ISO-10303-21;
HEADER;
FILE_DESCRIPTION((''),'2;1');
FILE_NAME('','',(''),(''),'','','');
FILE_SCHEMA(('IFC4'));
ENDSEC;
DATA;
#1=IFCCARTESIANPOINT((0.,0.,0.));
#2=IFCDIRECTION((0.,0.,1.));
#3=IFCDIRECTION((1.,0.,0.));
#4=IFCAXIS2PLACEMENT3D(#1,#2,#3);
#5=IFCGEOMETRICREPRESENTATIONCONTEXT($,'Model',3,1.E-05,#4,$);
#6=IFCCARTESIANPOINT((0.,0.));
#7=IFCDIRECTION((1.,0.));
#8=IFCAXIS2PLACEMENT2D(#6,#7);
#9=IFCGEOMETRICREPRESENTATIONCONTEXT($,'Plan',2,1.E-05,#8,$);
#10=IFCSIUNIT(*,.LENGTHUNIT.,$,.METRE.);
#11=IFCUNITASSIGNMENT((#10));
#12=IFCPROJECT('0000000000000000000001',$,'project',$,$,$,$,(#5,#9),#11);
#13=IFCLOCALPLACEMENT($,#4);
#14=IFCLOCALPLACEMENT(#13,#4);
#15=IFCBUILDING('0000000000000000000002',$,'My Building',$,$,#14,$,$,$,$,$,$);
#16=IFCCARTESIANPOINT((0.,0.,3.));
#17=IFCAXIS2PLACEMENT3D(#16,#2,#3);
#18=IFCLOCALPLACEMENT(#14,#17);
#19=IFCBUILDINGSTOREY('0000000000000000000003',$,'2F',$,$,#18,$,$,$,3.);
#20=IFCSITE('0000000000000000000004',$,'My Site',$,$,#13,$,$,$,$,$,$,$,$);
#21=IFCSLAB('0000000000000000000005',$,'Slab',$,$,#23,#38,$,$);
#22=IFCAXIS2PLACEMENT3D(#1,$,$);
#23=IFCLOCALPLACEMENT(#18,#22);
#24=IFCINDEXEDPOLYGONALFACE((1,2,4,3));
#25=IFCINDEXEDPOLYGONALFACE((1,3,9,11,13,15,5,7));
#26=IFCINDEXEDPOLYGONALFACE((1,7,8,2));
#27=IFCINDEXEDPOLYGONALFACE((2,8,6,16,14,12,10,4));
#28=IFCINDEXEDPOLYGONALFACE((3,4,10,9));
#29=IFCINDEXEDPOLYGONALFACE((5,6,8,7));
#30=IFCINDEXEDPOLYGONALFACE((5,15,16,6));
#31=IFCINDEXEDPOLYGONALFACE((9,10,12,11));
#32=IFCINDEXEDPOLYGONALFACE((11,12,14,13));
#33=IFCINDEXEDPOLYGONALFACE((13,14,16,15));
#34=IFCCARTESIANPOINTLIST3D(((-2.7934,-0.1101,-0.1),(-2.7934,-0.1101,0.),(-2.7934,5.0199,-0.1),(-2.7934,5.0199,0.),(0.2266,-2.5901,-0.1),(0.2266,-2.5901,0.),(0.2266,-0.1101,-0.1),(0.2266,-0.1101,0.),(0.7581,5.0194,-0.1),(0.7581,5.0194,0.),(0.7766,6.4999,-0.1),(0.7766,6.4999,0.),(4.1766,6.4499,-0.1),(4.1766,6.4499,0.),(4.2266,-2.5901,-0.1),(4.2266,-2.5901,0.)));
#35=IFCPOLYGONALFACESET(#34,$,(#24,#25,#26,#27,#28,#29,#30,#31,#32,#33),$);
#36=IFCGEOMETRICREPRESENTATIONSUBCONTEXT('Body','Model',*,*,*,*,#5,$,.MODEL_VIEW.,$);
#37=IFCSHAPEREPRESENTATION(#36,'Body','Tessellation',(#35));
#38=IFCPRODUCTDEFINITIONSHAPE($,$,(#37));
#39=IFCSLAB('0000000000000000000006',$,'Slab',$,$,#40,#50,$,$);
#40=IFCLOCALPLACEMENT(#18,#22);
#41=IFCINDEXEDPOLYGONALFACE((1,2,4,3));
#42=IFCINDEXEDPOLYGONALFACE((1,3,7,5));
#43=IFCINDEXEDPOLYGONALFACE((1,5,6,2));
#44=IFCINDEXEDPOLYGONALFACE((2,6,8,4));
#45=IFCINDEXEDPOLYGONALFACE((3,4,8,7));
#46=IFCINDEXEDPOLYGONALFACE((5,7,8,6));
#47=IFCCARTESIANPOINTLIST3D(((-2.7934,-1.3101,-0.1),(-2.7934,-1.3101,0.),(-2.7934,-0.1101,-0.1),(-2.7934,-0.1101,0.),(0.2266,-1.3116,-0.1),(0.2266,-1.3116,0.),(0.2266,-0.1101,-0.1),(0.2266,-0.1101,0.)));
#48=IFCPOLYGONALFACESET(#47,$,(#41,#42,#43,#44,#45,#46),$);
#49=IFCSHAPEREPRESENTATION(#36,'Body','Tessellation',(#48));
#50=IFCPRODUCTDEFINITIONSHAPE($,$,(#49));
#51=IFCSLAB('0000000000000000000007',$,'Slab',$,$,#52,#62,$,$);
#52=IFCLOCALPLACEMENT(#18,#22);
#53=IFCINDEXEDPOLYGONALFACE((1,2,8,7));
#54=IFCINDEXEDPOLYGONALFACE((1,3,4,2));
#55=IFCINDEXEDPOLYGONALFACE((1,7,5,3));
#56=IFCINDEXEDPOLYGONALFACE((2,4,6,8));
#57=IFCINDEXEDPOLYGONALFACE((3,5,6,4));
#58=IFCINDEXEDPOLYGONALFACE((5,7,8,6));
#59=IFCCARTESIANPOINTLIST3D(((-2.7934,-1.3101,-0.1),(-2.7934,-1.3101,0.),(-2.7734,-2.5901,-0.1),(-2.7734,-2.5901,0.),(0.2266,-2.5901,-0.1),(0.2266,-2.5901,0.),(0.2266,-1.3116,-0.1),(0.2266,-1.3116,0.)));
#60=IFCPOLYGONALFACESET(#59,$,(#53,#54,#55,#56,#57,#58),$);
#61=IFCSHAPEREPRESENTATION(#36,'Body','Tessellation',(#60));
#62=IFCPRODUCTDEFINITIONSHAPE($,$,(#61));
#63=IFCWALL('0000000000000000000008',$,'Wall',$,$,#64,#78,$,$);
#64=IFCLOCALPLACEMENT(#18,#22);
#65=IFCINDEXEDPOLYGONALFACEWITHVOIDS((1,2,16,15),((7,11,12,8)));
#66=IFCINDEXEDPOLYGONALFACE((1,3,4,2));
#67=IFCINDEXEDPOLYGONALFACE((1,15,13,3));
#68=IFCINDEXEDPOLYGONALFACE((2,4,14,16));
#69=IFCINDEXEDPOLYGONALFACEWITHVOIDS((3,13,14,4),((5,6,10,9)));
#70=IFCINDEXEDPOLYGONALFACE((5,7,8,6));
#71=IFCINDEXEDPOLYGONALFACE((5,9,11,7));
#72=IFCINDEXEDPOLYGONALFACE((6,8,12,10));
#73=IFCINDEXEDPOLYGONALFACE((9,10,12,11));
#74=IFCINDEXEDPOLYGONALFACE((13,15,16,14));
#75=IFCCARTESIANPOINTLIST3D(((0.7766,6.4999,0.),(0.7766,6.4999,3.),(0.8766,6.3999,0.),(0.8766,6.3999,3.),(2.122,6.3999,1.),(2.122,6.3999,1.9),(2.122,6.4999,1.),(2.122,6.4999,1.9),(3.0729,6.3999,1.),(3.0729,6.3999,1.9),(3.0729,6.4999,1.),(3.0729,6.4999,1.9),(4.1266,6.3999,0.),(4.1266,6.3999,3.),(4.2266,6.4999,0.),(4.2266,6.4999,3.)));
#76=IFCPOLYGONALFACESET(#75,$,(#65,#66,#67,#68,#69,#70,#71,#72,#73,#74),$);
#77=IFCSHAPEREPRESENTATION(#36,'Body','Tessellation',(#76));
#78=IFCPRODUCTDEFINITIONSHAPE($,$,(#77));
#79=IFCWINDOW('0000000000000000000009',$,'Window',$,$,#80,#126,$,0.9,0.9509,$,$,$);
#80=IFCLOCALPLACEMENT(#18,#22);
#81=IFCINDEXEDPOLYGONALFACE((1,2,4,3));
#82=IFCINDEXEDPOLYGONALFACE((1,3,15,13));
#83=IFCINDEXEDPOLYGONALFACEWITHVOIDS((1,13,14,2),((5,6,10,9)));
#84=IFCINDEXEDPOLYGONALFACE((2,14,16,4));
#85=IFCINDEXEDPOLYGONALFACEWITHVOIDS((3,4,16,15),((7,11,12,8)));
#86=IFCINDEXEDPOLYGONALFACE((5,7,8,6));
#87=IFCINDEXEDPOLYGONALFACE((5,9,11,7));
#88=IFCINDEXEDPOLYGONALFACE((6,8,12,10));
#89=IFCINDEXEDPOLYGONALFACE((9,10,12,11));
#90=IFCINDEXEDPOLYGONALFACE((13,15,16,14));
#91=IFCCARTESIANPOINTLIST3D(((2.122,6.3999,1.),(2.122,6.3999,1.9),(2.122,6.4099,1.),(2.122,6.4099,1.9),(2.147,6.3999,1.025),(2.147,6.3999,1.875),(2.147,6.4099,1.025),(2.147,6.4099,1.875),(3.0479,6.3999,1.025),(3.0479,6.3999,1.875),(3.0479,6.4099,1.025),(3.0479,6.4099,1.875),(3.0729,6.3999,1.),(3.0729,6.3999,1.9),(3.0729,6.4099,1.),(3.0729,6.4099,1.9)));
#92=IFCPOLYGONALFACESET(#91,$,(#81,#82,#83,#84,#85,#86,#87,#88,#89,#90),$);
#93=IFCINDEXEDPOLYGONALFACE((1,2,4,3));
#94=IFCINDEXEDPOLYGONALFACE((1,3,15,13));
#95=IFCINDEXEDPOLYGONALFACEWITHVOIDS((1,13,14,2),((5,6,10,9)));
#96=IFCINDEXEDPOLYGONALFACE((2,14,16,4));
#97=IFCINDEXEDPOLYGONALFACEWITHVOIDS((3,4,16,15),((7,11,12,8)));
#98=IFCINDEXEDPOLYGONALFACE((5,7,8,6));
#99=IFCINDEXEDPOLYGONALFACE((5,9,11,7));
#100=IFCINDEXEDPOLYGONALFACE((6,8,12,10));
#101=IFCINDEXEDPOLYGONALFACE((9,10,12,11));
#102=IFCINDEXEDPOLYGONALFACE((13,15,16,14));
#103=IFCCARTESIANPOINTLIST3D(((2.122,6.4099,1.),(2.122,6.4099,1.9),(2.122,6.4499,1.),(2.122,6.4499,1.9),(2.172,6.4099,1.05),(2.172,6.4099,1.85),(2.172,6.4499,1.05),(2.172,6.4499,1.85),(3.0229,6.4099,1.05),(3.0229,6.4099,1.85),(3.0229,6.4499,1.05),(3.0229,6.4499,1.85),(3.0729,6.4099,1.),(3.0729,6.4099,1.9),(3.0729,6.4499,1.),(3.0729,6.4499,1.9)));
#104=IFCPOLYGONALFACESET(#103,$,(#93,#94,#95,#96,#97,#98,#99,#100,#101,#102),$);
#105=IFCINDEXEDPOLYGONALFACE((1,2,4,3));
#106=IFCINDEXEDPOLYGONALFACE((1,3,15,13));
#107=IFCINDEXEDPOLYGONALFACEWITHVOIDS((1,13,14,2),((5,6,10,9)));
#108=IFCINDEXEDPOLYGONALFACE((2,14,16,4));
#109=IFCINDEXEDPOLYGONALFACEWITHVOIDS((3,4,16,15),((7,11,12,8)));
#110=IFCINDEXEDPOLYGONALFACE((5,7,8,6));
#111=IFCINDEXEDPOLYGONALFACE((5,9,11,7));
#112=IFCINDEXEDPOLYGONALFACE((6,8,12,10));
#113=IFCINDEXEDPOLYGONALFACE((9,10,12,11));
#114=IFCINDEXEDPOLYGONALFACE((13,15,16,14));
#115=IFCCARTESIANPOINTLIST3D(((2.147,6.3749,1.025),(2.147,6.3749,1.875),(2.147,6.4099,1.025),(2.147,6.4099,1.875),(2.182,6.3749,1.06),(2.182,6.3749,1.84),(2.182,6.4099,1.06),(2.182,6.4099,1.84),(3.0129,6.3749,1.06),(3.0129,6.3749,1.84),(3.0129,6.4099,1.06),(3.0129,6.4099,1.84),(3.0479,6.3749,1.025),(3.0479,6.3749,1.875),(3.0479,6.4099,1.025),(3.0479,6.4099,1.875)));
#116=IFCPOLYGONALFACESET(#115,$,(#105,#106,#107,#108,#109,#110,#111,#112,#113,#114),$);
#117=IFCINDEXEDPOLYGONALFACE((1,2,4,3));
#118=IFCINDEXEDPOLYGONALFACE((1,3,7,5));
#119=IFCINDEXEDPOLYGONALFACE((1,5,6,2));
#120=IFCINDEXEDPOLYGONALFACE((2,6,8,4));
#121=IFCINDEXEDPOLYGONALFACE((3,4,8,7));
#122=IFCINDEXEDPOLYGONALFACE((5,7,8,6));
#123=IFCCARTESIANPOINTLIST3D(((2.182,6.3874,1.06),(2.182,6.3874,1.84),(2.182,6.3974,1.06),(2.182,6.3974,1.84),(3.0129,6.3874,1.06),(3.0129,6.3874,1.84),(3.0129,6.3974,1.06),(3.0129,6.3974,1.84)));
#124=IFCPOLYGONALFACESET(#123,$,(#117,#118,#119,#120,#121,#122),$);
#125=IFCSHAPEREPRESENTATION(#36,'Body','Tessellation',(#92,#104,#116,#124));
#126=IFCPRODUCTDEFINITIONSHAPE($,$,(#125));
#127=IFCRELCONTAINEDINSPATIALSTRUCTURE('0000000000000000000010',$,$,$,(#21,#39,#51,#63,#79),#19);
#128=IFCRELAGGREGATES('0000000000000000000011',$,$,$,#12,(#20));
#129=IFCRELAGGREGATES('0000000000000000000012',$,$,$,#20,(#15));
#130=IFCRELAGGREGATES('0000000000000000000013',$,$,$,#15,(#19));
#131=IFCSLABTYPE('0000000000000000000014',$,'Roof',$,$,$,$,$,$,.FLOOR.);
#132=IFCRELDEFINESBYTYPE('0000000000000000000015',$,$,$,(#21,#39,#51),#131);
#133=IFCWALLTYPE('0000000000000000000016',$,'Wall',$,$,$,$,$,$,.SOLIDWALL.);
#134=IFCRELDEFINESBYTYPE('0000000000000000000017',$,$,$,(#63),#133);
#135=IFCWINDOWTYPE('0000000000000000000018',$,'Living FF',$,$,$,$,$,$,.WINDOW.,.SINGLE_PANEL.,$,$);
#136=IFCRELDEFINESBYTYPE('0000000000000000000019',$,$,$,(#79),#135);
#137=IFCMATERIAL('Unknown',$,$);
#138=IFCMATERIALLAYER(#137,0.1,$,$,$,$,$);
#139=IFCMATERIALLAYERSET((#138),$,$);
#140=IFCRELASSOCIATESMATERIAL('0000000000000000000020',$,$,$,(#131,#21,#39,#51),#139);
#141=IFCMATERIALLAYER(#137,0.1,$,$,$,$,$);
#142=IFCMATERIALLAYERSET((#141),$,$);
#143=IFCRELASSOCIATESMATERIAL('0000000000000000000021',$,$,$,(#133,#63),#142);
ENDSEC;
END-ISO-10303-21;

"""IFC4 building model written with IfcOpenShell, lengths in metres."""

from ifc_helpers import new_model, entity, si_unit, frame, origin_with_axes, origin_2d_with_axis, place, context, subcontext, project, spatial, line, indexed_curve, outline, extrude, shape, source, transform, mapped, material, layer, layer_set, layer_usage, type_object, type_shapes, element, fill, save


model = new_model("IFC4")

# Units and contexts
model_context = context("Model", 3, precision=1e-05, world=origin_with_axes())
plan_context = context("Plan", 2, precision=1e-05, world=origin_2d_with_axis())
body_context_1 = subcontext(model_context, "Body", "Model", "MODEL_VIEW")
body_context_2 = subcontext(plan_context, "Body", "Plan", "PLAN_VIEW")
ifc_project = project(units=[si_unit("LENGTHUNIT", "METRE")], contexts=[model_context, plan_context])

# Site, building, storey
site_placement = place(None, origin_with_axes())
site = spatial("IfcSite", under=ifc_project, at=site_placement, Name="My Site")
building_placement = place(site_placement, origin_with_axes())
building = spatial("IfcBuilding", under=site, at=building_placement, Name="My Building")
storey_placement = place(building_placement, frame((0.0, 0.0, 3.0), z_axis=(0.0, 0.0, 1.0), x_axis=(1.0, 0.0, 0.0)))
storey = spatial("IfcBuildingStorey", under=building, at=storey_placement, Name="2F", Elevation=3.0)

# Slabs
ifc_material = material(Name="Unknown")
ifc_layer_1 = layer(ifc_material, 0.1)
ifc_layer_set_1 = layer_set([ifc_layer_1])
ifc_layer_usage_1 = layer_usage(ifc_layer_set_1, "AXIS3", "POSITIVE", -0.1)
slab_type = type_object("IfcSlabType", Name="Roof", PredefinedType="FLOOR", material=ifc_layer_set_1)
slab_1_placement = place(storey_placement, frame((0.2266, -2.5901, 0.0), z_axis=(0.0, 0.0, 1.0), x_axis=(1.0, 0.0, 0.0)))
element("IfcSlab", 1, at=slab_1_placement, inside=storey, type_object=slab_type, material=ifc_layer_usage_1, Name="Slab", context=body_context_1, shape_type="SweptSolid", body=[
    extrude(outline(indexed_curve([(0.0, 0.0), (4.0, 0.0), (3.95, 9.04), (0.55, 9.09), (0.5314, 7.6095), (-3.02, 7.61), (-3.02, 2.48), (0.0, 2.48), (0.0, 0.0)])), frame((0.0, 0.0, -0.1), z_axis=(0.0, 0.0, 1.0), x_axis=(1.0, 0.0, 0.0)), (0.0, 0.0, 1.0), 0.1),
])
ifc_layer_usage_2 = layer_usage(ifc_layer_set_1, "AXIS3", "POSITIVE", -0.1)
slab_2_placement = place(storey_placement, frame((-2.7934, -0.1101, 0.0), z_axis=(0.0, 0.0, 1.0), x_axis=(1.0, 0.0, 0.0)))
element("IfcSlab", 2, at=slab_2_placement, inside=storey, type_object=slab_type, material=ifc_layer_usage_2, Name="Slab", context=body_context_1, shape_type="SweptSolid", body=[
    extrude(outline(indexed_curve([(0.0, 0.0), (0.0, -1.2), (3.02, -1.2015), (3.02, 0.0), (0.0, 0.0)])), frame((0.0, 0.0, -0.1), z_axis=(0.0, 0.0, 1.0), x_axis=(1.0, 0.0, 0.0)), (0.0, 0.0, 1.0), 0.1),
])
ifc_layer_usage_3 = layer_usage(ifc_layer_set_1, "AXIS3", "POSITIVE", -0.1)
slab_3_placement = place(storey_placement, frame((0.2266, -2.5901, 0.0), z_axis=(0.0, 0.0, 1.0), x_axis=(1.0, 0.0, 0.0)))
element("IfcSlab", 3, at=slab_3_placement, inside=storey, type_object=slab_type, material=ifc_layer_usage_3, Name="Slab", context=body_context_1, shape_type="SweptSolid", body=[
    extrude(outline(indexed_curve([(0.0, 0.0), (-3.0, 0.0), (-3.02, 1.28), (0.0, 1.2785), (0.0, 0.0)])), frame((0.0, 0.0, -0.1), z_axis=(0.0, 0.0, 1.0), x_axis=(1.0, 0.0, 0.0)), (0.0, 0.0, 1.0), 0.1),
])

# Wall, opening, window
ifc_layer_2 = layer(ifc_material, 0.1)
ifc_layer_set_2 = layer_set([ifc_layer_2])
ifc_layer_usage_4 = layer_usage(ifc_layer_set_2, "AXIS2", "POSITIVE", 0.0)
wall_type = type_object("IfcWallType", Name="Wall", PredefinedType="SOLIDWALL", material=ifc_layer_set_2)
wall_1_placement = place(storey_placement, frame((4.2266, 6.4999, 0.0), z_axis=(0.0, 0.0, 1.0), x_axis=(-1.0, 0.0, 0.0)))
wall_1 = element("IfcWall", 4, at=wall_1_placement, inside=storey, type_object=wall_type, material=ifc_layer_usage_4, Name="Wall", context=body_context_1, shape_type="SweptSolid", body=[
    extrude(outline(indexed_curve([(0.0, 0.0), (0.1, 0.1), (3.35, 0.1), (3.45, 0.0)], segments=[line(1, 2, 3, 4, 1)])), origin_with_axes(), (0.0, 0.0, 1.0), 3.0),
])
shared_shape_1 = source(origin_with_axes(), body_context_1, "Body", "SweptSolid", [
    extrude(outline(indexed_curve([(0.0, 0.0), (0.9509, 0.0), (0.9509, 0.9), (0.0, 0.9)], segments=[line(1, 2, 3, 4, 1)])), frame((0.0, -0.6, 0.0), z_axis=(0.0, -1.0, 0.0), x_axis=(1.0, 0.0, 0.0)), (0.0, 0.0, -1.0), 1.2),
])
opening_1_placement = place(wall_1_placement, frame((1.1537, 0.0, 1.0), z_axis=(0.0, 0.0, 1.0), x_axis=(1.0, 0.0, 0.0)))
opening_1 = element("IfcOpeningElement", 5, at=opening_1_placement, cuts=wall_1, PredefinedType="OPENING", context=body_context_1, shape_type="MappedRepresentation", body=[
    mapped(shared_shape_1, transform((0.0, 0.0, 0.0), x_axis=(1.0, 0.0, 0.0), y_axis=(0.0, 1.0, 0.0), z_axis=(0.0, 0.0, 1.0), scale=1.0)),
])
window_type_1 = type_object("IfcWindowType", Name="Living FF", PartitioningType="SINGLE_PANEL", PredefinedType="WINDOW")
shared_shape_2 = source(origin_with_axes(), body_context_1, "Body", "SweptSolid", [
    extrude(outline(indexed_curve([(0.0, 0.0), (0.9509, 0.0), (0.9509, 0.9), (0.0, 0.9)], segments=[line(1, 2, 3, 4, 1)]), holes=[indexed_curve([(0.025, 0.025), (0.9259, 0.025), (0.9259, 0.875), (0.025, 0.875)], segments=[line(1, 2, 3, 4, 1)])]), frame((0.0, 0.09, 0.0), z_axis=(0.0, -1.0, 0.0), x_axis=(1.0, 0.0, 0.0)), (0.0, 0.0, -1.0), 0.01),
    extrude(outline(indexed_curve([(0.0, 0.0), (0.9509, 0.0), (0.9509, 0.9), (0.0, 0.9)], segments=[line(1, 2, 3, 4, 1)]), holes=[indexed_curve([(0.05, 0.05), (0.9009, 0.05), (0.9009, 0.85), (0.05, 0.85)], segments=[line(1, 2, 3, 4, 1)])]), frame((0.0, 0.05, 0.0), z_axis=(0.0, -1.0, 0.0), x_axis=(1.0, 0.0, 0.0)), (0.0, 0.0, -1.0), 0.04),
    extrude(outline(indexed_curve([(0.0, 0.0), (0.9009, 0.0), (0.9009, 0.85), (0.0, 0.85)], segments=[line(1, 2, 3, 4, 1)]), holes=[indexed_curve([(0.035, 0.035), (0.8659, 0.035), (0.8659, 0.815), (0.035, 0.815)], segments=[line(1, 2, 3, 4, 1)])]), frame((0.025, 0.09, 0.025), z_axis=(0.0, -1.0, 0.0), x_axis=(1.0, 0.0, 0.0)), (0.0, 0.0, -1.0), 0.035),
    extrude(outline(indexed_curve([(0.035, 0.035), (0.8659, 0.035), (0.8659, 0.815), (0.035, 0.815)], segments=[line(1, 2, 3, 4, 1)])), frame((0.025, 0.1025, 0.025), z_axis=(0.0, -1.0, 0.0), x_axis=(1.0, 0.0, 0.0)), (0.0, 0.0, -1.0), 0.01),
])
shared_shape_3 = source(origin_with_axes(), body_context_2, "Body", "Curve2D", [
    entity("IfcIndexedPolyCurve", entity("IfcCartesianPointList2D", [[0.05, 0.05], [0.9009, 0.05]])),
    entity("IfcIndexedPolyCurve", entity("IfcCartesianPointList2D", [[0.0, 0.1], [0.025, 0.1], [0.025, 0.09], [0.05, 0.09], [0.05, 0.05], [0.0, 0.05]]), [entity("IfcLineIndex", [1, 2, 3, 4, 5, 6, 1])]),
    entity("IfcIndexedPolyCurve", entity("IfcCartesianPointList2D", [[0.9509, 0.1], [0.9259, 0.1], [0.9259, 0.09], [0.9009, 0.09], [0.9009, 0.05], [0.9509, 0.05]]), [entity("IfcLineIndex", [1, 2, 3, 4, 5, 6, 1])]),
    entity("IfcIndexedPolyCurve", entity("IfcCartesianPointList2D", [[0.025, 0.09], [0.06, 0.09], [0.06, 0.125], [0.025, 0.125]]), [entity("IfcLineIndex", [1, 2, 3, 4, 1])]),
    entity("IfcIndexedPolyCurve", entity("IfcCartesianPointList2D", [[0.9259, 0.09], [0.8909, 0.09], [0.8909, 0.125], [0.9259, 0.125]]), [entity("IfcLineIndex", [1, 2, 3, 4, 1])]),
    entity("IfcIndexedPolyCurve", entity("IfcCartesianPointList2D", [[0.06, 0.09], [0.8909, 0.09]])),
    entity("IfcIndexedPolyCurve", entity("IfcCartesianPointList2D", [[0.06, 0.125], [0.8909, 0.125]])),
    entity("IfcIndexedPolyCurve", entity("IfcCartesianPointList2D", [[0.06, 0.1075], [0.8909, 0.1075]])),
])
type_shapes(window_type_1, [shared_shape_2, shared_shape_3])
window_1_placement = place(opening_1_placement, frame((0.0, 0.0, 0.0), z_axis=(0.0, 0.0, 1.0), x_axis=(1.0, 0.0, 0.0)))
window_1 = element("IfcWindow", 6, at=window_1_placement, inside=storey, type_object=window_type_1, Name="Window", OverallHeight=0.9, OverallWidth=0.9509, shapes=[
    shape(body_context_1, "Body", "MappedRepresentation", [mapped(shared_shape_2, transform((0.0, 0.0, 0.0), x_axis=(1.0, 0.0, 0.0), y_axis=(0.0, 1.0, 0.0), z_axis=(0.0, 0.0, 1.0), scale=1.0))]),
    shape(body_context_2, "Body", "MappedRepresentation", [mapped(shared_shape_3, transform((0.0, 0.0, 0.0), x_axis=(1.0, 0.0, 0.0), y_axis=(0.0, 1.0, 0.0), z_axis=(0.0, 0.0, 1.0), scale=1.0))]),
])
fill(opening_1, window_1)

save(model, "model.ifc")
